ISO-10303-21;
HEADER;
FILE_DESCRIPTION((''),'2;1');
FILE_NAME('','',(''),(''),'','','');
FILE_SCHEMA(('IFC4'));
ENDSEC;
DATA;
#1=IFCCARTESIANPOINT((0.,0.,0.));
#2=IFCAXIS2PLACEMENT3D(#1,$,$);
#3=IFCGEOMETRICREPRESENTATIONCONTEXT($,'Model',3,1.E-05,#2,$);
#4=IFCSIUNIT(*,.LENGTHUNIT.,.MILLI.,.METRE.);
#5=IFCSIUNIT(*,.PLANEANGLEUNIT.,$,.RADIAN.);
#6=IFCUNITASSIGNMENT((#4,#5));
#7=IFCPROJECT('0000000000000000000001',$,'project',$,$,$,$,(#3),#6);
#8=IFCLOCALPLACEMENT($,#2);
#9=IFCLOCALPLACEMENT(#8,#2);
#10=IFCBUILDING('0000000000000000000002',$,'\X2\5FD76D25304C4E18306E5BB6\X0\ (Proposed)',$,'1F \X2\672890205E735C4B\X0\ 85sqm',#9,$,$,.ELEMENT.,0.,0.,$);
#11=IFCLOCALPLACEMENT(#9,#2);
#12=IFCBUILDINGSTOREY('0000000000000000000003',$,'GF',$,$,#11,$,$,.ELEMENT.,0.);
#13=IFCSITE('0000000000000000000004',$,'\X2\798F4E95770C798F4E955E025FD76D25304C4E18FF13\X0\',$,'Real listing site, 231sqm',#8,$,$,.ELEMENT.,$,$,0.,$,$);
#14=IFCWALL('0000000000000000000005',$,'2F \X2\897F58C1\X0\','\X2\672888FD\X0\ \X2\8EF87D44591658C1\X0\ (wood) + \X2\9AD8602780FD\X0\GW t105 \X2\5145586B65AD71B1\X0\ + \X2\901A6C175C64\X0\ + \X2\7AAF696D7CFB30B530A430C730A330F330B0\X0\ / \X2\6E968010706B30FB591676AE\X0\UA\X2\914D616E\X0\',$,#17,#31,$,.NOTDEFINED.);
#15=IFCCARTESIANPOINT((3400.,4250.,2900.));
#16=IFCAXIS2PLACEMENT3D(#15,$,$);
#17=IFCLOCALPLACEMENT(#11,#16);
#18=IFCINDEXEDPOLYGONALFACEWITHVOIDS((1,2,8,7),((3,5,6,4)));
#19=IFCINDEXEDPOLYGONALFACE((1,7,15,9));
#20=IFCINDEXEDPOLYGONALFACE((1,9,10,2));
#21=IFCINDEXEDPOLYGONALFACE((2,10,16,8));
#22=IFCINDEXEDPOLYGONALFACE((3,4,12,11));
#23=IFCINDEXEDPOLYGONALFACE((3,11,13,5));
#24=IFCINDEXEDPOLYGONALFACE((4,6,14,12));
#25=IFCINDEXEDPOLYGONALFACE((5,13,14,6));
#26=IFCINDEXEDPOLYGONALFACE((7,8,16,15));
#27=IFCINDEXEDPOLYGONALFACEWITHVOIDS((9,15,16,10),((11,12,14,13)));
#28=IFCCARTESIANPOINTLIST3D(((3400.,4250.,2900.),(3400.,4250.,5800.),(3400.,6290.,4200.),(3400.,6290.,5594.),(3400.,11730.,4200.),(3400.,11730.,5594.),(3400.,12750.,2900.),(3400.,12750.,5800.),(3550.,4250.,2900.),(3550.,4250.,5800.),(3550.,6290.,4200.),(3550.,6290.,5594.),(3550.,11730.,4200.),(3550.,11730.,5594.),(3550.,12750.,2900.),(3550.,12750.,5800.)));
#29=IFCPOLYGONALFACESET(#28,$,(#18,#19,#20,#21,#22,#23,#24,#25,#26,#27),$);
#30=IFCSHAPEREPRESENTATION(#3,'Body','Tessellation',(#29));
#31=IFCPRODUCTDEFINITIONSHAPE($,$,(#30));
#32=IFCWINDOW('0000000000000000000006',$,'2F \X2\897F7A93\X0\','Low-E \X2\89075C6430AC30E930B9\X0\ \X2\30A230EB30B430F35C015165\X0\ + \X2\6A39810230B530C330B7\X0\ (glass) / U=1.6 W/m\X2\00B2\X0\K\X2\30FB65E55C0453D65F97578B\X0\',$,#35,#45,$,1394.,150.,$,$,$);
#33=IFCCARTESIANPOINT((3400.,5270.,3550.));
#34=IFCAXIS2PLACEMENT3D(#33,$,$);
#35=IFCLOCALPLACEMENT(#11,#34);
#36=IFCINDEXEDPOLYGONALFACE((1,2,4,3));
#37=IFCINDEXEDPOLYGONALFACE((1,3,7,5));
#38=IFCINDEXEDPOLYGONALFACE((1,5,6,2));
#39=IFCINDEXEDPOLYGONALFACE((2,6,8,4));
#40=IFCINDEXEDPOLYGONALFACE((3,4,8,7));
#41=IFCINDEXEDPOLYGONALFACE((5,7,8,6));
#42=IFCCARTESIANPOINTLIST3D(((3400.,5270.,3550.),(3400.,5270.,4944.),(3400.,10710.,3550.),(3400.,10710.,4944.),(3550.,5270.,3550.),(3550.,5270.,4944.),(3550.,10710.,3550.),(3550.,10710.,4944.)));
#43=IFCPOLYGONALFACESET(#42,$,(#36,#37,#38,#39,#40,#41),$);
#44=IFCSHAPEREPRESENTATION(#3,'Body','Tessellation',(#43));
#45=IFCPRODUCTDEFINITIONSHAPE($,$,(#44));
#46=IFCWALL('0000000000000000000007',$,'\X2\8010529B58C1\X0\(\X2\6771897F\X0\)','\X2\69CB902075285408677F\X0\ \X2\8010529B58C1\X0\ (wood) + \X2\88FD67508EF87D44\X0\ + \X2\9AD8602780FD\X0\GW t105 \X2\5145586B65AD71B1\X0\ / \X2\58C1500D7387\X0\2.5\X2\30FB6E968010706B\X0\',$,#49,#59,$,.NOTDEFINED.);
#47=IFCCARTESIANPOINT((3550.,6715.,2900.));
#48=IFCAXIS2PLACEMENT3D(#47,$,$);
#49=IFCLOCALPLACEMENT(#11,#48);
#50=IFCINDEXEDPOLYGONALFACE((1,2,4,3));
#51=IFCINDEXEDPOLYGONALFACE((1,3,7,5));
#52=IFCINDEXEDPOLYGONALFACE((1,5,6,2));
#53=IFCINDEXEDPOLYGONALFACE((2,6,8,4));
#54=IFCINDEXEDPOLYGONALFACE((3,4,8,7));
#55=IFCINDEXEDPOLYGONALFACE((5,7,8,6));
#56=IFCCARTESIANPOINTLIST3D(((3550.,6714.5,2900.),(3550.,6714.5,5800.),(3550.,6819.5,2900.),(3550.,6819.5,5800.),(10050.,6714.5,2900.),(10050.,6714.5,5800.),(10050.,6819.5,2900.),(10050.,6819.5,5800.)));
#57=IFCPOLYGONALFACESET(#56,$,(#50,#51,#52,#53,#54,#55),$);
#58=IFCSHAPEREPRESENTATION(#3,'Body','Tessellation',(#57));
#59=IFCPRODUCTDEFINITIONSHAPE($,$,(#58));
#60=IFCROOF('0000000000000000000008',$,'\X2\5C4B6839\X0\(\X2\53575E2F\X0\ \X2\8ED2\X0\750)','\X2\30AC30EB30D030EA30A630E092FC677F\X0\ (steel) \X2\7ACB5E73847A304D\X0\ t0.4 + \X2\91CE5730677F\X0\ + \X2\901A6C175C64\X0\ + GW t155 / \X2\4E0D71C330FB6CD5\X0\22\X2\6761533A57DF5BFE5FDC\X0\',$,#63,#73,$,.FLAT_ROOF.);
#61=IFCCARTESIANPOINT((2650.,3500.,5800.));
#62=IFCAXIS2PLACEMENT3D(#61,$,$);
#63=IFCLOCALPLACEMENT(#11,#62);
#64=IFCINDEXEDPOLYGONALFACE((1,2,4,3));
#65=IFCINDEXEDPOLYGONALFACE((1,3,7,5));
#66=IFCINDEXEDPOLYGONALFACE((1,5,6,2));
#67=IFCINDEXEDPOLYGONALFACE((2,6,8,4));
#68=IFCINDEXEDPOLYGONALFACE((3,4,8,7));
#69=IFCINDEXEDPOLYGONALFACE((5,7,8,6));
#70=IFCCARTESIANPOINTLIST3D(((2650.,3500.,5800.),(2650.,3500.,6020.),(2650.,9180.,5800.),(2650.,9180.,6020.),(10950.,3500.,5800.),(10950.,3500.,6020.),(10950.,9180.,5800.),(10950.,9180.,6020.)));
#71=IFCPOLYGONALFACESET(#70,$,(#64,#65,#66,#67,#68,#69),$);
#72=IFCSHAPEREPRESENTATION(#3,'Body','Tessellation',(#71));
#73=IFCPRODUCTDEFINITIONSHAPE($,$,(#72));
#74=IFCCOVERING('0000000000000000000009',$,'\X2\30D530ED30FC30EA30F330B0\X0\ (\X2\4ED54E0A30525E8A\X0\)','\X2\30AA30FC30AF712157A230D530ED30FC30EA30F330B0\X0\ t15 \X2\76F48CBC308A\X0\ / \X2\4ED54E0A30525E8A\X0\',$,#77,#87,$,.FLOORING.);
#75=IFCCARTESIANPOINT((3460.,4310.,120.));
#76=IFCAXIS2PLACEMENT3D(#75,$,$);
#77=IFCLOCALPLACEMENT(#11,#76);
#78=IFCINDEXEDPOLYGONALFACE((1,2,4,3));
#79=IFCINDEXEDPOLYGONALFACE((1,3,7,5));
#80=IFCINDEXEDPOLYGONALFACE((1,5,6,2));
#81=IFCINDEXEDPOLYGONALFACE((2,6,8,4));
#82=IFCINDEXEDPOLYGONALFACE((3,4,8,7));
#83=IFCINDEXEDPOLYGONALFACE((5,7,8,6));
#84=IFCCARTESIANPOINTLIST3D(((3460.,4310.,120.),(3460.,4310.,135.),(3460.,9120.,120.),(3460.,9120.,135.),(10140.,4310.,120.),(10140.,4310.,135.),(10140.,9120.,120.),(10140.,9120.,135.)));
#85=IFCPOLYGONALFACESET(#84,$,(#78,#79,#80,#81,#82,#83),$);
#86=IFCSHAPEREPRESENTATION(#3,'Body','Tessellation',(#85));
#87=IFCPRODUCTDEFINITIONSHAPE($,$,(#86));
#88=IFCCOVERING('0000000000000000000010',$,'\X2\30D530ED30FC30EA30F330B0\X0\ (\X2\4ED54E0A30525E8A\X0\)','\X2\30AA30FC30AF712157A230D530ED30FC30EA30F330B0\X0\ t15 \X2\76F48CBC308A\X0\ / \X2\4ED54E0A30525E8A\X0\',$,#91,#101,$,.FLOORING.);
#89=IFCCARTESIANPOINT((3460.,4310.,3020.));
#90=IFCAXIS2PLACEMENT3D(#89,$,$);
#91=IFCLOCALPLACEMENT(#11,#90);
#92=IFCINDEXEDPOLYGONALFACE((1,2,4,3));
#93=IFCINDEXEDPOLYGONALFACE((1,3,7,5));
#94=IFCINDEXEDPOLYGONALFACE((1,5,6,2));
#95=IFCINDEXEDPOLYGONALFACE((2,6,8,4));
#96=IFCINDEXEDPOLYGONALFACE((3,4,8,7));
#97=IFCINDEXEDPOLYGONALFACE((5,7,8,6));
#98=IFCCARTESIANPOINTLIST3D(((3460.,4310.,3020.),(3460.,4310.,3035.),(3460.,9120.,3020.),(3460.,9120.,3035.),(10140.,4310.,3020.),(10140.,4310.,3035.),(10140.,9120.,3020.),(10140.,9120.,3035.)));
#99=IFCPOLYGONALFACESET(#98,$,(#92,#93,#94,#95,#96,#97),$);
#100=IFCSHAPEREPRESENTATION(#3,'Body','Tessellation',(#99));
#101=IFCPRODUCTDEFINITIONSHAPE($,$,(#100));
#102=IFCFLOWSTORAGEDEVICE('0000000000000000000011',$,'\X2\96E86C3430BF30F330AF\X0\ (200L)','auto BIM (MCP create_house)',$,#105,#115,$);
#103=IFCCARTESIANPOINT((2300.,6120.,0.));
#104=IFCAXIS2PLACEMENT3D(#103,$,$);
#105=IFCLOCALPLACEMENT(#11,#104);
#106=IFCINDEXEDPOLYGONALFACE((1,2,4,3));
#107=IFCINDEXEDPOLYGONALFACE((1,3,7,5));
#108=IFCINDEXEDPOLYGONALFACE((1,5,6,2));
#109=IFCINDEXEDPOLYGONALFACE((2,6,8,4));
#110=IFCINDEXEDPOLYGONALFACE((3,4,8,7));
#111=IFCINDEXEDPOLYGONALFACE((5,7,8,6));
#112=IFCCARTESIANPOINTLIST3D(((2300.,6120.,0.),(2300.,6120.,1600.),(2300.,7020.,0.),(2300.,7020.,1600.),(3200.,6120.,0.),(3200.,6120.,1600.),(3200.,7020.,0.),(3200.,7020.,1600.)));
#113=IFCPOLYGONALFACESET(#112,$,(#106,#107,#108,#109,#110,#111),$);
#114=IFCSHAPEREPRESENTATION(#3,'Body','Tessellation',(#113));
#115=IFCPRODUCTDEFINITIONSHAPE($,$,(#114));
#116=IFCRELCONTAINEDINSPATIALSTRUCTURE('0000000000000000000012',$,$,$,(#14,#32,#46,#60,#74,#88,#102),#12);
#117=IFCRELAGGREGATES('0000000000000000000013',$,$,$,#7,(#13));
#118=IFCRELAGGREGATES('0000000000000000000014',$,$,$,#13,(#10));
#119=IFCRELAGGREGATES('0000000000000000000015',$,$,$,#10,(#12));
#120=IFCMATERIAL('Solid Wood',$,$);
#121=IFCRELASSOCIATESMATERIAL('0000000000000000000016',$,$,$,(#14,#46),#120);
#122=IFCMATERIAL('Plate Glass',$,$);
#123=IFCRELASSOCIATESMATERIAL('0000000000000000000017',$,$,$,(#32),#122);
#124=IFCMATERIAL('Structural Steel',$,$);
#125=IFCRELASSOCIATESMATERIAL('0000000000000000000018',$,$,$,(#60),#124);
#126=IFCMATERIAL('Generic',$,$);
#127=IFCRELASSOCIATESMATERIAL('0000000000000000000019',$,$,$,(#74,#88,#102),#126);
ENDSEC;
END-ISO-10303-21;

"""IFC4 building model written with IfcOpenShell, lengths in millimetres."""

from ifc_helpers import new_model, si_unit, frame, frame_2d, origin, place, context, project, spatial, rectangle, extrude, material, element, fill, save


model = new_model("IFC4")

# Units and contexts
model_context = context("Model", 3, precision=1e-05, world=origin())
ifc_project = project(units=[si_unit("LENGTHUNIT", "METRE", prefix="MILLI"), si_unit("PLANEANGLEUNIT", "RADIAN")], contexts=[model_context])

# Site, building, storey
site_placement = place(None, origin())
site = spatial("IfcSite", under=ifc_project, at=site_placement, Name="福井県福井市志津が丘３", ObjectType="Real listing site, 231sqm", CompositionType="ELEMENT", RefElevation=0.0)
building_placement = place(site_placement, origin())
building = spatial("IfcBuilding", under=site, at=building_placement, Name="志津が丘の家 (Proposed)", ObjectType="1F 木造平屋 85sqm", CompositionType="ELEMENT", ElevationOfRefHeight=0.0, ElevationOfTerrain=0.0)
storey_placement = place(building_placement, origin())
storey = spatial("IfcBuildingStorey", under=building, at=storey_placement, Name="GF", CompositionType="ELEMENT", Elevation=0.0)

# Shared definitions
ifc_material_1 = material(Name="Solid Wood")
ifc_material_2 = material(Name="Generic")

# Shared definitions
ifc_material_3 = material(Name="Plate Glass")

# Wall, opening, window
wall_1_placement = place(storey_placement, frame((3400.0, 4250.0, 2900.0)))
wall_1 = element("IfcWall", 1, at=wall_1_placement, inside=storey, material=ifc_material_1, Name="2F 西壁", Description="木製 軸組外壁 (wood) + 高性能GW t105 充填断熱 + 通気層 + 窯業系サイディング / 準耐火・外皮UA配慮", PredefinedType="NOTDEFINED", context=model_context, shape_type="SweptSolid", body=[
    extrude(rectangle(XDim=150.0, YDim=8500.0, at=frame_2d((75.0, 4250.0))), frame((3400.0, 4250.0, 2900.0)), (0.0, 0.0, 1.0), 2900.0),
])
opening_1_placement = place(storey_placement, frame((3400.0, 5270.0, 3550.0)))
opening_1 = element("IfcOpeningElement", 2, at=opening_1_placement, cuts=wall_1, PredefinedType="NOTDEFINED", context=model_context, shape_type="SweptSolid", body=[
    extrude(rectangle(XDim=150.0, YDim=5440.0, at=frame_2d((75.0, 2720.0))), frame((3400.0, 5270.0, 3550.0)), (0.0, 0.0, 1.0), 1394.0),
])
window_1_placement = place(storey_placement, frame((3400.0, 5270.0, 3550.0)))
window_1 = element("IfcWindow", 3, at=window_1_placement, inside=storey, material=ifc_material_3, Name="2F 西窓", Description="Low-E 複層ガラス アルゴン封入 + 樹脂サッシ (glass) / U=1.6 W/m²K・日射取得型", OverallHeight=1394.0, OverallWidth=150.0, context=model_context, shape_type="SweptSolid", body=[
    extrude(rectangle(XDim=150.0, YDim=5440.0, at=frame_2d((75.0, 2720.0))), frame((3400.0, 5270.0, 3550.0)), (0.0, 0.0, 1.0), 1394.0),
])
fill(opening_1, window_1)

# Wall
wall_2_placement = place(storey_placement, frame((3550.0, 6715.0, 2900.0)))
element("IfcWall", 4, at=wall_2_placement, inside=storey, material=ifc_material_1, Name="耐力壁(東西)", Description="構造用合板 耐力壁 (wood) + 製材軸組 + 高性能GW t105 充填断熱 / 壁倍率2.5・準耐火", PredefinedType="NOTDEFINED", context=model_context, shape_type="SweptSolid", body=[
    extrude(rectangle(XDim=6500.0, YDim=105.0, at=frame_2d((3250.0, 52.0))), frame((3550.0, 6715.0, 2900.0)), (0.0, 0.0, 1.0), 2900.0),
])

# Roof
ifc_material_4 = material(Name="Structural Steel")
for number, where, name in (
    (5, (2650.0, 3500.0, 5800.0), "屋根(南帯 軒750)"),
):
    element("IfcRoof", number, at=place(storey_placement, frame(where)), inside=storey, material=ifc_material_4, Name=name, Description="ガルバリウム鋼板 (steel) 立平葺き t0.4 + 野地板 + 通気層 + GW t155 / 不燃・法22条区域対応", PredefinedType="FLAT_ROOF", context=model_context, shape_type="SweptSolid", body=[
        extrude(rectangle(XDim=8300.0, YDim=5680.0, at=frame_2d((4150.0, 2840.0))), frame((2650.0, 3500.0, 5800.0)), (0.0, 0.0, 1.0), 220.0),
    ])

# Coverings
covering_1_placement = place(storey_placement, frame((3460.0, 4310.0, 120.0)))
element("IfcCovering", 6, at=covering_1_placement, inside=storey, material=ifc_material_2, Name="フローリング (仕上げ床)", Description="オーク無垢フローリング t15 直貼り / 仕上げ床", PredefinedType="FLOORING", context=model_context, shape_type="SweptSolid", body=[
    extrude(rectangle(XDim=6680.0, YDim=4810.0, at=frame_2d((3340.0, 2405.0))), frame((3460.0, 4310.0, 120.0)), (0.0, 0.0, 1.0), 15.0),
])
covering_2_placement = place(storey_placement, frame((3460.0, 4310.0, 3020.0)))
element("IfcCovering", 7, at=covering_2_placement, inside=storey, material=ifc_material_2, Name="フローリング (仕上げ床)", Description="オーク無垢フローリング t15 直貼り / 仕上げ床", PredefinedType="FLOORING", context=model_context, shape_type="SweptSolid", body=[
    extrude(rectangle(XDim=6680.0, YDim=4810.0, at=frame_2d((3340.0, 2405.0))), frame((3460.0, 4310.0, 3020.0)), (0.0, 0.0, 1.0), 15.0),
])

# Flow storage device
flow_storage_device_placement = place(storey_placement, frame((2300.0, 6120.0, 0.0)))
element("IfcFlowStorageDevice", 8, at=flow_storage_device_placement, inside=storey, material=ifc_material_2, Name="雨水タンク (200L)", Description="auto BIM (MCP create_house)", context=model_context, shape_type="SweptSolid", body=[
    extrude(rectangle(XDim=900.0, YDim=900.0, at=frame_2d((450.0, 450.0))), frame((2300.0, 6120.0, 0.0)), (0.0, 0.0, 1.0), 1600.0),
])

save(model, "model.ifc")
